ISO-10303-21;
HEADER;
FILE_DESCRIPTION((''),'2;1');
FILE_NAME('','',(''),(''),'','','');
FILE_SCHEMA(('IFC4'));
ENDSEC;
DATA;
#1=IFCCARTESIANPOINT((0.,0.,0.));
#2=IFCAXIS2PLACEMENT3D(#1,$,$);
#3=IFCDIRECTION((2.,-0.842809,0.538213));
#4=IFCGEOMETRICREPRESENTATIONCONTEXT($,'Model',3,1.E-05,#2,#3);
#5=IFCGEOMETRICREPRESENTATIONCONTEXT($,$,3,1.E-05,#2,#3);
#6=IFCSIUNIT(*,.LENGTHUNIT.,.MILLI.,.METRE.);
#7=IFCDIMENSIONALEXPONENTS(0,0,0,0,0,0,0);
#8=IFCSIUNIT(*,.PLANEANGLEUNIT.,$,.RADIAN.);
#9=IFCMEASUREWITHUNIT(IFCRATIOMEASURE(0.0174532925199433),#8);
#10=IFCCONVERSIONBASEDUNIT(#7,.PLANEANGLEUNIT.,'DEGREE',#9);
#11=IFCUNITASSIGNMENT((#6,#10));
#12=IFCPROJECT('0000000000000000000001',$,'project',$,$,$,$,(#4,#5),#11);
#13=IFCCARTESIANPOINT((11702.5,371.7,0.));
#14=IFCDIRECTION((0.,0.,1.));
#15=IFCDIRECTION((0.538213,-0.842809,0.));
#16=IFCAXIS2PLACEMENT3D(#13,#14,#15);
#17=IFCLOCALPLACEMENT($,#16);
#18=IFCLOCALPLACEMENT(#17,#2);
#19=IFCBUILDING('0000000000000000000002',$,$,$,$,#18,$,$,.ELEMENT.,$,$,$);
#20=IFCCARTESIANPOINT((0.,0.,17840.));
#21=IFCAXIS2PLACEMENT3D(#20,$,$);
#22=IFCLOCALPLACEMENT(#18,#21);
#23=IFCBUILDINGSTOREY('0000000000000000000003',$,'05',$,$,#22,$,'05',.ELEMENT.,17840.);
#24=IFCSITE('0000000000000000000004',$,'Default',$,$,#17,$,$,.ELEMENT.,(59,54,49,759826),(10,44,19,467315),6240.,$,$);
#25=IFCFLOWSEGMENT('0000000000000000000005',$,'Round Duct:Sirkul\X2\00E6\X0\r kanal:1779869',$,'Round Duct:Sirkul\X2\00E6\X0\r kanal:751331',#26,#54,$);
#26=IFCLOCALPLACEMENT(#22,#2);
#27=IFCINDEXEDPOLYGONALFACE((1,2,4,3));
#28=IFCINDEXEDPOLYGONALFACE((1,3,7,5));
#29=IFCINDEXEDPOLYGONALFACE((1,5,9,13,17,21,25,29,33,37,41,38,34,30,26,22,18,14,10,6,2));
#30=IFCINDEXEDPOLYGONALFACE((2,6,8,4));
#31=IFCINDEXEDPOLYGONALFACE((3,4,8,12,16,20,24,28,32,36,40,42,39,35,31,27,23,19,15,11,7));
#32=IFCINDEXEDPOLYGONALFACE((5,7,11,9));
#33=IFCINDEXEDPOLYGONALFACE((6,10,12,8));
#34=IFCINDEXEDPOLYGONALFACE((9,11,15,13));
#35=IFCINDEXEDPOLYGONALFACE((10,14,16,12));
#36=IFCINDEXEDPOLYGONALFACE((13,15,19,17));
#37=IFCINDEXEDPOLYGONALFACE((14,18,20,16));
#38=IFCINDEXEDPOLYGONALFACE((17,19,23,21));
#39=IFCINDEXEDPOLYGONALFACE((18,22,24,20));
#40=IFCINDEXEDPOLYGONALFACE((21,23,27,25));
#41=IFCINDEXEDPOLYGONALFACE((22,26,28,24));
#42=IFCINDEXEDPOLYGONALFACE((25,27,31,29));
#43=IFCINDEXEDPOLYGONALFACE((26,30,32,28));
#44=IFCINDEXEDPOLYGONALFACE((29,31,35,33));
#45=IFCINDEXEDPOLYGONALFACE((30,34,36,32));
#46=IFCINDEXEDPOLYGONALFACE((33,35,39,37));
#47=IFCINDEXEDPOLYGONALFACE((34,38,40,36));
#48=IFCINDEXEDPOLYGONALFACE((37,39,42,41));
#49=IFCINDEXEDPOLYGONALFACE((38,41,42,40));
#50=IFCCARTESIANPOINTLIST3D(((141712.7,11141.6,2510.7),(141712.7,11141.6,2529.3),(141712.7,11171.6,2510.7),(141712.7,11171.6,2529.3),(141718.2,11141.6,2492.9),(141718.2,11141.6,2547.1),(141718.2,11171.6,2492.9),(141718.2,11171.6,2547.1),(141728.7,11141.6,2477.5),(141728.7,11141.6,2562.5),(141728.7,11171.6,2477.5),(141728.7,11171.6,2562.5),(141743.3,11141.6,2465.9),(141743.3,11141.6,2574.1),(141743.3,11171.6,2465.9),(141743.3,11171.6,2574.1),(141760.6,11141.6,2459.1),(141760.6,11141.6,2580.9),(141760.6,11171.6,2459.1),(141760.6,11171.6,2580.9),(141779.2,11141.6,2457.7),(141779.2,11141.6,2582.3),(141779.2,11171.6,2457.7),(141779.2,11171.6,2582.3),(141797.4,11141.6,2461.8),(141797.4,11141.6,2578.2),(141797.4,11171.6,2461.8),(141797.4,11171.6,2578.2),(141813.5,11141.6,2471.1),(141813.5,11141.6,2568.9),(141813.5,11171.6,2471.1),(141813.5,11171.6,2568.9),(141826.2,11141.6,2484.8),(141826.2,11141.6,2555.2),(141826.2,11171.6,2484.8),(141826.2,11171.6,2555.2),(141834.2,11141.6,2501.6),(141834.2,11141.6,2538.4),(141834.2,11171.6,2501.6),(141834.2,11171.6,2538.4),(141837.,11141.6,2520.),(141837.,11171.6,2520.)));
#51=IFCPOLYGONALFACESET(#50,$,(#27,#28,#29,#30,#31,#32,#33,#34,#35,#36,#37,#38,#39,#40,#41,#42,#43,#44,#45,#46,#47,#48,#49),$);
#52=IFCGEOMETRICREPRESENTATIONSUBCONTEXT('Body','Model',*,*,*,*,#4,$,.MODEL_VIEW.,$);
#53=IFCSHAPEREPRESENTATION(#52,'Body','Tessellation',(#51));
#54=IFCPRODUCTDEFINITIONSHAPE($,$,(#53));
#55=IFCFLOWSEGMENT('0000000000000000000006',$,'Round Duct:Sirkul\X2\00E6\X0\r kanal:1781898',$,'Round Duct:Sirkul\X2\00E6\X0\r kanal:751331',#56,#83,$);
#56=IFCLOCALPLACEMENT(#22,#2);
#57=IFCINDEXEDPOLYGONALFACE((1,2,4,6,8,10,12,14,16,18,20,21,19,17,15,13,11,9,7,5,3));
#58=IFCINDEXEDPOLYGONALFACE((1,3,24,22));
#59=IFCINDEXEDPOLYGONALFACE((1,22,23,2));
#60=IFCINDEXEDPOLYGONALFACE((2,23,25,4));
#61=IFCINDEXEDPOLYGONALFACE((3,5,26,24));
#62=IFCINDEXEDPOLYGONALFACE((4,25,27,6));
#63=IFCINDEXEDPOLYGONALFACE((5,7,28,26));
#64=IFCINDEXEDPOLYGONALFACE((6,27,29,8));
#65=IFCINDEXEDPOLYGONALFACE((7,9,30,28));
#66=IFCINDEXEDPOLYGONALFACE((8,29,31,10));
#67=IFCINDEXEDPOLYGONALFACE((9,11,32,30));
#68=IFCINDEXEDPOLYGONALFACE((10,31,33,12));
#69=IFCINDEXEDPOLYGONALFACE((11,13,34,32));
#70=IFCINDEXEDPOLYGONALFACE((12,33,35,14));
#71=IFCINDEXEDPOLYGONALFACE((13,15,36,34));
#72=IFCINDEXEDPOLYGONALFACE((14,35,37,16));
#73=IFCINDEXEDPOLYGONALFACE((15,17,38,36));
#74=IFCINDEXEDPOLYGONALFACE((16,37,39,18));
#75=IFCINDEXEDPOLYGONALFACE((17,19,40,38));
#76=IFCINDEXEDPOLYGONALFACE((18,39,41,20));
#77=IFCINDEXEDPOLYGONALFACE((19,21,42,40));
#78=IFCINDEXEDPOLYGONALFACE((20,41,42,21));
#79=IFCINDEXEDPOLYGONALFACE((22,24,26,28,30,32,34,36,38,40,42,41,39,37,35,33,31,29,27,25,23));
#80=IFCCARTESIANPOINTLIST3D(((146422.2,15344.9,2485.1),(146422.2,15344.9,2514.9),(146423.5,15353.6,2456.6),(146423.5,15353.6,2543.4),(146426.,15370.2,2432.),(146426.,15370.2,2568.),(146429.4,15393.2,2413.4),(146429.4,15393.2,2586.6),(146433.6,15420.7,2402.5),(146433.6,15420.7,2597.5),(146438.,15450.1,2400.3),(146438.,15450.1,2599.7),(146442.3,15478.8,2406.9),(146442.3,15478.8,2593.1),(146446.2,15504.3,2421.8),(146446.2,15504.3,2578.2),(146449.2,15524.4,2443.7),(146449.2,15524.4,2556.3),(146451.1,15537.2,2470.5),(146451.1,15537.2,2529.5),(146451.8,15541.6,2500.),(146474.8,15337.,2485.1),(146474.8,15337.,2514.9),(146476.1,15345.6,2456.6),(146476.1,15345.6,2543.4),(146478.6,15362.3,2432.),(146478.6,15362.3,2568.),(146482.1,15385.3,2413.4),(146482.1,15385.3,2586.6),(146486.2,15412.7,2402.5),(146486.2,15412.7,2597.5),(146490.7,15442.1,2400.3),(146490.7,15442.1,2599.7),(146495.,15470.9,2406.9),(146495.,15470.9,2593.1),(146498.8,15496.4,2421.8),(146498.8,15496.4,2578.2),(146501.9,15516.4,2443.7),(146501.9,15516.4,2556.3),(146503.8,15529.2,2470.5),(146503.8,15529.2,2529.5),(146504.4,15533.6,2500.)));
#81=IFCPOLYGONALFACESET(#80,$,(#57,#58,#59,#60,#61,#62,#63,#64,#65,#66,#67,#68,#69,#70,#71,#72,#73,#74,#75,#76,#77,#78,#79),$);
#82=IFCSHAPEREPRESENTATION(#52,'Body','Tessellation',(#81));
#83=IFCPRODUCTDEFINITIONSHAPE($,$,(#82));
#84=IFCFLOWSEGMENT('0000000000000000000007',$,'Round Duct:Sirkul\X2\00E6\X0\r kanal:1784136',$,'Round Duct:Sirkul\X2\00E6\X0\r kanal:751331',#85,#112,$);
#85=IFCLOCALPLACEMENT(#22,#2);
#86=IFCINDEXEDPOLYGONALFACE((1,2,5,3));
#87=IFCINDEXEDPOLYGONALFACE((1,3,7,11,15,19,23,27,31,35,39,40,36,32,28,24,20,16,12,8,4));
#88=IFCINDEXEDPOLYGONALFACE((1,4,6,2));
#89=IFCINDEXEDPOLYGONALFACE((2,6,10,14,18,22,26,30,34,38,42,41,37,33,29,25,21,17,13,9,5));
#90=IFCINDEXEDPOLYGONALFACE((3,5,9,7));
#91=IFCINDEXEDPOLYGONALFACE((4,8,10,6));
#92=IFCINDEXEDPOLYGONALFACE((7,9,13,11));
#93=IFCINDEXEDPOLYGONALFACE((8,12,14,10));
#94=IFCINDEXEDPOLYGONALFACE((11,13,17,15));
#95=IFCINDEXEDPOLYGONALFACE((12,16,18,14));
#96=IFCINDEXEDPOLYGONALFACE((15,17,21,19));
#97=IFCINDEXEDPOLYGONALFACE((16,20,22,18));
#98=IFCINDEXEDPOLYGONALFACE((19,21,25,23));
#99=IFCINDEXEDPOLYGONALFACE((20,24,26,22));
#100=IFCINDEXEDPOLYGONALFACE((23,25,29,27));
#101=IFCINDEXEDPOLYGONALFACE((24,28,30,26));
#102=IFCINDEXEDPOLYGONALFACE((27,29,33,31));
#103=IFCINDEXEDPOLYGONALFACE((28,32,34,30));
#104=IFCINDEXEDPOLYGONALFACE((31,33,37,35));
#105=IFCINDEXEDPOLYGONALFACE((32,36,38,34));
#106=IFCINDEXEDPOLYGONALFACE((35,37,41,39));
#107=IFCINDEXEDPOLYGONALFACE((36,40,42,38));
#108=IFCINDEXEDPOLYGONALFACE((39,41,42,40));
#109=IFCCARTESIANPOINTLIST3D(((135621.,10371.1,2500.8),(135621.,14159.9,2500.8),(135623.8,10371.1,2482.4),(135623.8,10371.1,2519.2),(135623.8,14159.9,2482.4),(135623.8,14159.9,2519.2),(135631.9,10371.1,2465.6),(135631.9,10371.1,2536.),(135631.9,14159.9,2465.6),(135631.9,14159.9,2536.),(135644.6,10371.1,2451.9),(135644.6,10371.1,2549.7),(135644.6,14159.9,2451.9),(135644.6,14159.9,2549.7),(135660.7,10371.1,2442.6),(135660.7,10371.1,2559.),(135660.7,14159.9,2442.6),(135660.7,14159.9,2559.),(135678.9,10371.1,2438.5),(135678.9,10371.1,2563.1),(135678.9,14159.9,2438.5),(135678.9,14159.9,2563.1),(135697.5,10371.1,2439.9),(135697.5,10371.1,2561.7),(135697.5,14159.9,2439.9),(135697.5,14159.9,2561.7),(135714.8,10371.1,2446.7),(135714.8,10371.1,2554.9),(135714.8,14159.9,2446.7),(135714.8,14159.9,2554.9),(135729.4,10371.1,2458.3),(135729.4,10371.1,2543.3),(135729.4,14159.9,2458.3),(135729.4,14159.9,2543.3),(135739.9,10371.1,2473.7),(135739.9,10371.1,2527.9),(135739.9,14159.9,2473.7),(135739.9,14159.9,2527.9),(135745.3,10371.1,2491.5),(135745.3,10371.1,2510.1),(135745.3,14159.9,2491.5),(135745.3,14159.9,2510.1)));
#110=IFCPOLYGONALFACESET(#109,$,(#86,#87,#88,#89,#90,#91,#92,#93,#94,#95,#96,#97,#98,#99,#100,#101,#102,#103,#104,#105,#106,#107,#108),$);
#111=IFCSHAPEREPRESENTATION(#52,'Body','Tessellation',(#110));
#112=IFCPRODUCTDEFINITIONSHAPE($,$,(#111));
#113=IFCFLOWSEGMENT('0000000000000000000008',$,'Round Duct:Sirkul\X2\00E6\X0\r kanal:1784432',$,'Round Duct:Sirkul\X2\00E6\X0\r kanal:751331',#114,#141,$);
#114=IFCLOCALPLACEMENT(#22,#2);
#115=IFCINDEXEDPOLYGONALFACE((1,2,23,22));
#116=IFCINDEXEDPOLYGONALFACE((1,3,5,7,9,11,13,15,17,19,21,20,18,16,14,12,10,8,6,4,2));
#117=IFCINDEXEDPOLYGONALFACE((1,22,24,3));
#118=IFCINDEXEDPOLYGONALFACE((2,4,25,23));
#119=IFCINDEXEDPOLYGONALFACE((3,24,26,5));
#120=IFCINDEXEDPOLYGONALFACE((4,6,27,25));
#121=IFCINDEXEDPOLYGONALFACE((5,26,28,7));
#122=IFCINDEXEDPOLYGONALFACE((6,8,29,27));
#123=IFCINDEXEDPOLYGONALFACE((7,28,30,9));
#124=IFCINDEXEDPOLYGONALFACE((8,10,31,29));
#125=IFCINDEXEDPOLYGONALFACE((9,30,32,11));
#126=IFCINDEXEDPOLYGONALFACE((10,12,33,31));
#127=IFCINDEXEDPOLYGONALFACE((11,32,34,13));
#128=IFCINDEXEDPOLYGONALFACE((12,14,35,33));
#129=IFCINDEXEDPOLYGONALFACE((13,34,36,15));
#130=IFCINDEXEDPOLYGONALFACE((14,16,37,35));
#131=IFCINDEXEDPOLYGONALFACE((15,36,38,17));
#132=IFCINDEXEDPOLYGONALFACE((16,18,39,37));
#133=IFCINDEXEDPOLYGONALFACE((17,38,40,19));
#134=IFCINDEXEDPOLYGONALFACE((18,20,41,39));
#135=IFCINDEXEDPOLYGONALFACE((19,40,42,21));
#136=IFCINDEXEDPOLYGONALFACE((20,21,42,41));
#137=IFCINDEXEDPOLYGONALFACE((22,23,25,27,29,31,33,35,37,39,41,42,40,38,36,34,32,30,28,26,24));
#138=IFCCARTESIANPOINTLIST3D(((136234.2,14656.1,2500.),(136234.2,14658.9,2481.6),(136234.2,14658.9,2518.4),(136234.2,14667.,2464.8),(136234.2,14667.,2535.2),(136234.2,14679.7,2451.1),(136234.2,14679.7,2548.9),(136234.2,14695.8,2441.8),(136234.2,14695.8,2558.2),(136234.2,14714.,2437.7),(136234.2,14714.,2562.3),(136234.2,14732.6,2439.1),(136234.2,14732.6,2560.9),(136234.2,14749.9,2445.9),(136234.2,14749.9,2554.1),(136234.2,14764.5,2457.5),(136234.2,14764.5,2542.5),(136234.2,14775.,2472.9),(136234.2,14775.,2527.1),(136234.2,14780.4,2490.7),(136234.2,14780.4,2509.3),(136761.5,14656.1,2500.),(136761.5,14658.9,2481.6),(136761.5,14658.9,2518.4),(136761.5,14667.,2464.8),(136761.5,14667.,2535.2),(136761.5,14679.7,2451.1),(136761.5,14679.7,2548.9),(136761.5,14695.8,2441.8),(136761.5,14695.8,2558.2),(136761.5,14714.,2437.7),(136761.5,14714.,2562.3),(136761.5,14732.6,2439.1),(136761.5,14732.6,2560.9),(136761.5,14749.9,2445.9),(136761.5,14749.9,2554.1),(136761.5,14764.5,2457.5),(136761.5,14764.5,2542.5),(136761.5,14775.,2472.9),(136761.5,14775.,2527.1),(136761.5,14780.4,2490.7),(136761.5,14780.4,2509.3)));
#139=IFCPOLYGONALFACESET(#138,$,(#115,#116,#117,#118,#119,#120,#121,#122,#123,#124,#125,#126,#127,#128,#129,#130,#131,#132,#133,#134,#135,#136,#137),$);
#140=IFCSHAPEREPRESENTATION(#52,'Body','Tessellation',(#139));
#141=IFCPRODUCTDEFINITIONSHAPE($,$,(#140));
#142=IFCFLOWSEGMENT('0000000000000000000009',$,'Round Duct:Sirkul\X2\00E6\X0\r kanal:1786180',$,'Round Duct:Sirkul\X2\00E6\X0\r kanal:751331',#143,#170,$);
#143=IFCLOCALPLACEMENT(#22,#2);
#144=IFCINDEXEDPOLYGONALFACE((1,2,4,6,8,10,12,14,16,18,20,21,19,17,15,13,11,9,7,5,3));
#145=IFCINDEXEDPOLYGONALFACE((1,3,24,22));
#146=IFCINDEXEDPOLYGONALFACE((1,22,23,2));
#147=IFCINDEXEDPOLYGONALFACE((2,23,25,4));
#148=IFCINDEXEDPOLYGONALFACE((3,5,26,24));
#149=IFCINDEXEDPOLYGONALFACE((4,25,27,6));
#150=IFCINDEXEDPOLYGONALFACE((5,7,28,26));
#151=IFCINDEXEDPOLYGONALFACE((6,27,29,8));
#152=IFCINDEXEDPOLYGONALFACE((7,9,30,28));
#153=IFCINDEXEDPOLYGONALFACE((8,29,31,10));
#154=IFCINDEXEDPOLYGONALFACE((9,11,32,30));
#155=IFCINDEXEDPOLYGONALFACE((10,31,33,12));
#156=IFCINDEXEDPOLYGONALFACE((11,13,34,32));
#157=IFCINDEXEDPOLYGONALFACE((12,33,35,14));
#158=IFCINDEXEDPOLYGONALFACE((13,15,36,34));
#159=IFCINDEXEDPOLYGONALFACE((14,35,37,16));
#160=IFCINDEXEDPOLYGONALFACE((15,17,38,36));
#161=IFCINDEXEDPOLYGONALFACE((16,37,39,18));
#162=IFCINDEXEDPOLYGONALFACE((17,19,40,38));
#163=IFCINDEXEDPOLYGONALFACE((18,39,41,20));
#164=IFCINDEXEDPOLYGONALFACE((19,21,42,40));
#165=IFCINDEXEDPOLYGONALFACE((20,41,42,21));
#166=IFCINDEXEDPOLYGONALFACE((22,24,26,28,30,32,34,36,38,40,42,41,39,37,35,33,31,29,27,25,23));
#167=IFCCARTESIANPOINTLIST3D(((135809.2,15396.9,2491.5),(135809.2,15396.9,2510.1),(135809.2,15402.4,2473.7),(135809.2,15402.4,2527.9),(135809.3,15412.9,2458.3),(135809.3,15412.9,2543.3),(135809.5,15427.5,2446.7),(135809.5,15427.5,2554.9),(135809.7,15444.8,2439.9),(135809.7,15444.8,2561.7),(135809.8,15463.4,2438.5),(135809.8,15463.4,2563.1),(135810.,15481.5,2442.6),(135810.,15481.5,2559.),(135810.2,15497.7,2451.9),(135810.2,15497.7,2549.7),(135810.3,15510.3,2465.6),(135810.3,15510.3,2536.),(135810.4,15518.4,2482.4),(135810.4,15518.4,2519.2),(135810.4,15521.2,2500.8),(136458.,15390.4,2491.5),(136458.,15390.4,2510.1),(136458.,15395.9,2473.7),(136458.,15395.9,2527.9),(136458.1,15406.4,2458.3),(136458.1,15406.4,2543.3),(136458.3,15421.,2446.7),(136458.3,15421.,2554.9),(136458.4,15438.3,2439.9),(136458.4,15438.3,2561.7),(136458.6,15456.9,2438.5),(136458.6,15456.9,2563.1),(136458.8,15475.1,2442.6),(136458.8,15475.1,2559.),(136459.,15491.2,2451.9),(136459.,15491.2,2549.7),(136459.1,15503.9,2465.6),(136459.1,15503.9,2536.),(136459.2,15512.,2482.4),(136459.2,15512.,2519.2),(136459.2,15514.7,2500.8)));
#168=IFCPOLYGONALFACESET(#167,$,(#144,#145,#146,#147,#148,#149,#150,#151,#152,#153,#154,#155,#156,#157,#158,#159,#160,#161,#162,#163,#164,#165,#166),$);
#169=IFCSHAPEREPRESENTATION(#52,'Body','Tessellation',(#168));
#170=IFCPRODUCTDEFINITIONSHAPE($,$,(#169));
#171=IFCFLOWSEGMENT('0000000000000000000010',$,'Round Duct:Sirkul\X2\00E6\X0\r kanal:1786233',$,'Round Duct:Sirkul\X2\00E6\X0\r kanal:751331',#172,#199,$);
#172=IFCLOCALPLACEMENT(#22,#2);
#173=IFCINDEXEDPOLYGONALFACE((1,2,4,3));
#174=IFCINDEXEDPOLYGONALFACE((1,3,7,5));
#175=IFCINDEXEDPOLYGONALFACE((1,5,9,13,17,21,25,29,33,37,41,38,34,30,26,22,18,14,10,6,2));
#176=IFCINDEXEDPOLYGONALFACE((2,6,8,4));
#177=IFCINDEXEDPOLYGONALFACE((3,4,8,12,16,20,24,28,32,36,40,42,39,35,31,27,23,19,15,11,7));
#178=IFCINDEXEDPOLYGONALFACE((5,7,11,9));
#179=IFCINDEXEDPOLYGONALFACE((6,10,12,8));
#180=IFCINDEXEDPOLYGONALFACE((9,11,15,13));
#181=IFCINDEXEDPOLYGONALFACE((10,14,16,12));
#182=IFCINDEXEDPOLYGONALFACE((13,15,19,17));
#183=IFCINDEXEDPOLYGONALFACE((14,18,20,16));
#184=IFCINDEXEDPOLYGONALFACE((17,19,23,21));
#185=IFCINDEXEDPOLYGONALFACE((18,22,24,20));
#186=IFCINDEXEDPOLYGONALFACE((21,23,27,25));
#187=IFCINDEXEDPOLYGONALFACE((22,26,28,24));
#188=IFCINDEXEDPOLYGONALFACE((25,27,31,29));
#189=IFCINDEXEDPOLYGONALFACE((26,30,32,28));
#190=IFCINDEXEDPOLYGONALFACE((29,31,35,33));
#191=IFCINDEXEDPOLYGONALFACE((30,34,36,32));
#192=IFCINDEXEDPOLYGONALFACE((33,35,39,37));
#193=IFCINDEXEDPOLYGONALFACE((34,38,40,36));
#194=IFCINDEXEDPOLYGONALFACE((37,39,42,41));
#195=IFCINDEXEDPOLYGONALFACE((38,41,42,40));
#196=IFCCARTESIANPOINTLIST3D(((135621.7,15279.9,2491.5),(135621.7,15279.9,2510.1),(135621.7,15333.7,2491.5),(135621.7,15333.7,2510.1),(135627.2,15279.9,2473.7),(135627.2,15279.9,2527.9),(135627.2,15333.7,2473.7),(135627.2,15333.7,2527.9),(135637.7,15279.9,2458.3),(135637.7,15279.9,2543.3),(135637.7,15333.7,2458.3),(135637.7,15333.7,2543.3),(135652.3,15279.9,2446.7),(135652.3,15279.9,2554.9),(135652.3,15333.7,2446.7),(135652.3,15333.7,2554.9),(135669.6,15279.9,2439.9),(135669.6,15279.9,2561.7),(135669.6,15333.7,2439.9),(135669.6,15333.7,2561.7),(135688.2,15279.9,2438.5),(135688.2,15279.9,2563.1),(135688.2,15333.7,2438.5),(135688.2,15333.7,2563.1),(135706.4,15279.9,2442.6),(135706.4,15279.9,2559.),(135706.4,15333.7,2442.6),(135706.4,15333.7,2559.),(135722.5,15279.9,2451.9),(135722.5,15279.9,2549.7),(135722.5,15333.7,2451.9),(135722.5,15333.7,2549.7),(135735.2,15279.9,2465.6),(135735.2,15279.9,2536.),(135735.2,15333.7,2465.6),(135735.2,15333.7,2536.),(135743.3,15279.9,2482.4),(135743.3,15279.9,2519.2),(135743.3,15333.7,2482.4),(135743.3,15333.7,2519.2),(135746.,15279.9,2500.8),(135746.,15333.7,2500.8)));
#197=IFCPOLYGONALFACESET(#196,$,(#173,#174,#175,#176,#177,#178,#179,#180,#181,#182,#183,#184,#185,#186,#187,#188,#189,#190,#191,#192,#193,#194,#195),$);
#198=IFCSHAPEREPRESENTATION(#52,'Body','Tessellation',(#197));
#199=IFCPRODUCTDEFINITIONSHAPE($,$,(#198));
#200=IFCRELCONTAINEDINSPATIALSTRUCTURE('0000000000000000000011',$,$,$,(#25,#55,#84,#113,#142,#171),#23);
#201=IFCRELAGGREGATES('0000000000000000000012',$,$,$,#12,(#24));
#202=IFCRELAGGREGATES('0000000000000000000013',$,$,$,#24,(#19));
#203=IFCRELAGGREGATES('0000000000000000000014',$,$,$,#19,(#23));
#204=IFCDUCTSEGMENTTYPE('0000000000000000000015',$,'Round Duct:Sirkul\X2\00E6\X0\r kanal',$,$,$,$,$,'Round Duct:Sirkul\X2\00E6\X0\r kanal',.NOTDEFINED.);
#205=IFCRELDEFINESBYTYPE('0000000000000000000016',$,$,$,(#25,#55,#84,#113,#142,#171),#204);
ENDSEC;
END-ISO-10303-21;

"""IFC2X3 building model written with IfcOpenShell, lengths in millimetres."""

from ifc_helpers import new_model, entity, si_unit, converted_unit, direction, frame, frame_2d, origin, origin_2d_with_axis, place, context, subcontext, project, spatial, circle, extrude, type_object, element, save


model = new_model("IFC2X3")

# Units and contexts
model_context = context("Model", 3, precision=1e-05, world=origin(), true_north=direction((2.0, -0.842809, 0.538213)))
context_of_model = context(None, 3, precision=1e-05, world=origin(), true_north=direction((2.0, -0.842809, 0.538213)))
body_context = subcontext(model_context, "Body", "Model", "MODEL_VIEW")
ifc_project = project(units=[si_unit("LENGTHUNIT", "METRE", prefix="MILLI"), converted_unit("PLANEANGLEUNIT", "DEGREE", entity("IfcRatioMeasure", 0.0174532925199433), si_unit("PLANEANGLEUNIT", "RADIAN"), dimensions=[0, 0, 0, 0, 0, 0, 0])], contexts=[model_context, context_of_model])

# Site, building, storey
site_placement = place(None, frame((11702.5, 371.7, 0.0), z_axis=(0.0, 0.0, 1.0), x_axis=(0.538213, -0.842809, 0.0)))
site = spatial("IfcSite", under=ifc_project, at=site_placement, Name="Default", CompositionType="ELEMENT", RefLatitude=(59, 54, 49, 759826), RefLongitude=(10, 44, 19, 467315), RefElevation=6240.0)
building_placement = place(site_placement, origin())
building = spatial("IfcBuilding", under=site, at=building_placement, CompositionType="ELEMENT")
storey_placement = place(building_placement, frame((0.0, 0.0, 17840.0)))
storey = spatial("IfcBuildingStorey", under=building, at=storey_placement, Name="05", LongName="05", CompositionType="ELEMENT", Elevation=17840.0)

# Flow segments
duct_segment_type_1 = type_object("IfcDuctSegmentType", Name="Round Duct:Sirkulær kanal", ElementType="Round Duct:Sirkulær kanal", PredefinedType="NOTDEFINED")
flow_segment_1_placement = place(storey_placement, origin())
element("IfcFlowSegment", 1, at=flow_segment_1_placement, inside=storey, type_object=duct_segment_type_1, Name="Round Duct:Sirkulær kanal:1779869", ObjectType="Round Duct:Sirkulær kanal:751331", context=body_context, shape_type="SweptSolid", body=[
    extrude(circle(Radius=62.5, at=frame_2d((0.0, 0.0), x_axis=(1.0, 0.0))), frame((141774.5, 11141.6, 2520.0), z_axis=(0.0, 1.0, 0.0), x_axis=(1.0, 0.0, 0.0)), (0.0, 0.0, 1.0), 30.0),
])
flow_segment_2_placement = place(storey_placement, origin())
element("IfcFlowSegment", 2, at=flow_segment_2_placement, inside=storey, type_object=duct_segment_type_1, Name="Round Duct:Sirkulær kanal:1781898", ObjectType="Round Duct:Sirkulær kanal:751331", context=body_context, shape_type="SweptSolid", body=[
    extrude(circle(Radius=100.0, at=origin_2d_with_axis()), frame((146436.9, 15442.7, 2500.0), z_axis=(0.988855, -0.148881, 0.0), x_axis=(0.148881, 0.988855, 0.0)), (0.0, 0.0, 1.0), 53.3),
])
flow_segment_3_placement = place(storey_placement, origin())
element("IfcFlowSegment", 3, at=flow_segment_3_placement, inside=storey, type_object=duct_segment_type_1, Name="Round Duct:Sirkulær kanal:1784136", ObjectType="Round Duct:Sirkulær kanal:751331", context=body_context, shape_type="SweptSolid", body=[
    extrude(circle(Radius=62.5, at=origin_2d_with_axis()), frame((135683.5, 10371.1, 2500.8), z_axis=(0.0, 1.0, 0.0), x_axis=(-1.0, 0.0, 0.0)), (0.0, 0.0, 1.0), 3788.8),
])
flow_segment_4_placement = place(storey_placement, origin())
element("IfcFlowSegment", 4, at=flow_segment_4_placement, inside=storey, type_object=duct_segment_type_1, Name="Round Duct:Sirkulær kanal:1784432", ObjectType="Round Duct:Sirkulær kanal:751331", context=body_context, shape_type="SweptSolid", body=[
    extrude(circle(Radius=62.5, at=frame_2d((0.0, 0.0), x_axis=(1.0, 0.0))), frame((136234.2, 14718.6, 2500.0), z_axis=(1.0, 0.0, 0.0), x_axis=(0.0, -1.0, 0.0)), (0.0, 0.0, 1.0), 527.3),
])
flow_segment_5_placement = place(storey_placement, origin())
element("IfcFlowSegment", 5, at=flow_segment_5_placement, inside=storey, type_object=duct_segment_type_1, Name="Round Duct:Sirkulær kanal:1786180", ObjectType="Round Duct:Sirkulær kanal:751331", context=body_context, shape_type="SweptSolid", body=[
    extrude(circle(Radius=62.5, at=origin_2d_with_axis()), frame((135809.8, 15458.7, 2500.8), z_axis=(0.99995, -0.009958, 0.0), x_axis=(0.009958, 0.99995, 0.0)), (0.0, 0.0, 1.0), 648.8),
])
flow_segment_6_placement = place(storey_placement, origin())
element("IfcFlowSegment", 6, at=flow_segment_6_placement, inside=storey, type_object=duct_segment_type_1, Name="Round Duct:Sirkulær kanal:1786233", ObjectType="Round Duct:Sirkulær kanal:751331", context=body_context, shape_type="SweptSolid", body=[
    extrude(circle(Radius=62.5, at=origin_2d_with_axis()), frame((135683.5, 15279.9, 2500.8), z_axis=(0.0, 1.0, 0.0), x_axis=(1.0, 0.0, 0.0)), (0.0, 0.0, 1.0), 53.8),
])

save(model, "model.ifc")
